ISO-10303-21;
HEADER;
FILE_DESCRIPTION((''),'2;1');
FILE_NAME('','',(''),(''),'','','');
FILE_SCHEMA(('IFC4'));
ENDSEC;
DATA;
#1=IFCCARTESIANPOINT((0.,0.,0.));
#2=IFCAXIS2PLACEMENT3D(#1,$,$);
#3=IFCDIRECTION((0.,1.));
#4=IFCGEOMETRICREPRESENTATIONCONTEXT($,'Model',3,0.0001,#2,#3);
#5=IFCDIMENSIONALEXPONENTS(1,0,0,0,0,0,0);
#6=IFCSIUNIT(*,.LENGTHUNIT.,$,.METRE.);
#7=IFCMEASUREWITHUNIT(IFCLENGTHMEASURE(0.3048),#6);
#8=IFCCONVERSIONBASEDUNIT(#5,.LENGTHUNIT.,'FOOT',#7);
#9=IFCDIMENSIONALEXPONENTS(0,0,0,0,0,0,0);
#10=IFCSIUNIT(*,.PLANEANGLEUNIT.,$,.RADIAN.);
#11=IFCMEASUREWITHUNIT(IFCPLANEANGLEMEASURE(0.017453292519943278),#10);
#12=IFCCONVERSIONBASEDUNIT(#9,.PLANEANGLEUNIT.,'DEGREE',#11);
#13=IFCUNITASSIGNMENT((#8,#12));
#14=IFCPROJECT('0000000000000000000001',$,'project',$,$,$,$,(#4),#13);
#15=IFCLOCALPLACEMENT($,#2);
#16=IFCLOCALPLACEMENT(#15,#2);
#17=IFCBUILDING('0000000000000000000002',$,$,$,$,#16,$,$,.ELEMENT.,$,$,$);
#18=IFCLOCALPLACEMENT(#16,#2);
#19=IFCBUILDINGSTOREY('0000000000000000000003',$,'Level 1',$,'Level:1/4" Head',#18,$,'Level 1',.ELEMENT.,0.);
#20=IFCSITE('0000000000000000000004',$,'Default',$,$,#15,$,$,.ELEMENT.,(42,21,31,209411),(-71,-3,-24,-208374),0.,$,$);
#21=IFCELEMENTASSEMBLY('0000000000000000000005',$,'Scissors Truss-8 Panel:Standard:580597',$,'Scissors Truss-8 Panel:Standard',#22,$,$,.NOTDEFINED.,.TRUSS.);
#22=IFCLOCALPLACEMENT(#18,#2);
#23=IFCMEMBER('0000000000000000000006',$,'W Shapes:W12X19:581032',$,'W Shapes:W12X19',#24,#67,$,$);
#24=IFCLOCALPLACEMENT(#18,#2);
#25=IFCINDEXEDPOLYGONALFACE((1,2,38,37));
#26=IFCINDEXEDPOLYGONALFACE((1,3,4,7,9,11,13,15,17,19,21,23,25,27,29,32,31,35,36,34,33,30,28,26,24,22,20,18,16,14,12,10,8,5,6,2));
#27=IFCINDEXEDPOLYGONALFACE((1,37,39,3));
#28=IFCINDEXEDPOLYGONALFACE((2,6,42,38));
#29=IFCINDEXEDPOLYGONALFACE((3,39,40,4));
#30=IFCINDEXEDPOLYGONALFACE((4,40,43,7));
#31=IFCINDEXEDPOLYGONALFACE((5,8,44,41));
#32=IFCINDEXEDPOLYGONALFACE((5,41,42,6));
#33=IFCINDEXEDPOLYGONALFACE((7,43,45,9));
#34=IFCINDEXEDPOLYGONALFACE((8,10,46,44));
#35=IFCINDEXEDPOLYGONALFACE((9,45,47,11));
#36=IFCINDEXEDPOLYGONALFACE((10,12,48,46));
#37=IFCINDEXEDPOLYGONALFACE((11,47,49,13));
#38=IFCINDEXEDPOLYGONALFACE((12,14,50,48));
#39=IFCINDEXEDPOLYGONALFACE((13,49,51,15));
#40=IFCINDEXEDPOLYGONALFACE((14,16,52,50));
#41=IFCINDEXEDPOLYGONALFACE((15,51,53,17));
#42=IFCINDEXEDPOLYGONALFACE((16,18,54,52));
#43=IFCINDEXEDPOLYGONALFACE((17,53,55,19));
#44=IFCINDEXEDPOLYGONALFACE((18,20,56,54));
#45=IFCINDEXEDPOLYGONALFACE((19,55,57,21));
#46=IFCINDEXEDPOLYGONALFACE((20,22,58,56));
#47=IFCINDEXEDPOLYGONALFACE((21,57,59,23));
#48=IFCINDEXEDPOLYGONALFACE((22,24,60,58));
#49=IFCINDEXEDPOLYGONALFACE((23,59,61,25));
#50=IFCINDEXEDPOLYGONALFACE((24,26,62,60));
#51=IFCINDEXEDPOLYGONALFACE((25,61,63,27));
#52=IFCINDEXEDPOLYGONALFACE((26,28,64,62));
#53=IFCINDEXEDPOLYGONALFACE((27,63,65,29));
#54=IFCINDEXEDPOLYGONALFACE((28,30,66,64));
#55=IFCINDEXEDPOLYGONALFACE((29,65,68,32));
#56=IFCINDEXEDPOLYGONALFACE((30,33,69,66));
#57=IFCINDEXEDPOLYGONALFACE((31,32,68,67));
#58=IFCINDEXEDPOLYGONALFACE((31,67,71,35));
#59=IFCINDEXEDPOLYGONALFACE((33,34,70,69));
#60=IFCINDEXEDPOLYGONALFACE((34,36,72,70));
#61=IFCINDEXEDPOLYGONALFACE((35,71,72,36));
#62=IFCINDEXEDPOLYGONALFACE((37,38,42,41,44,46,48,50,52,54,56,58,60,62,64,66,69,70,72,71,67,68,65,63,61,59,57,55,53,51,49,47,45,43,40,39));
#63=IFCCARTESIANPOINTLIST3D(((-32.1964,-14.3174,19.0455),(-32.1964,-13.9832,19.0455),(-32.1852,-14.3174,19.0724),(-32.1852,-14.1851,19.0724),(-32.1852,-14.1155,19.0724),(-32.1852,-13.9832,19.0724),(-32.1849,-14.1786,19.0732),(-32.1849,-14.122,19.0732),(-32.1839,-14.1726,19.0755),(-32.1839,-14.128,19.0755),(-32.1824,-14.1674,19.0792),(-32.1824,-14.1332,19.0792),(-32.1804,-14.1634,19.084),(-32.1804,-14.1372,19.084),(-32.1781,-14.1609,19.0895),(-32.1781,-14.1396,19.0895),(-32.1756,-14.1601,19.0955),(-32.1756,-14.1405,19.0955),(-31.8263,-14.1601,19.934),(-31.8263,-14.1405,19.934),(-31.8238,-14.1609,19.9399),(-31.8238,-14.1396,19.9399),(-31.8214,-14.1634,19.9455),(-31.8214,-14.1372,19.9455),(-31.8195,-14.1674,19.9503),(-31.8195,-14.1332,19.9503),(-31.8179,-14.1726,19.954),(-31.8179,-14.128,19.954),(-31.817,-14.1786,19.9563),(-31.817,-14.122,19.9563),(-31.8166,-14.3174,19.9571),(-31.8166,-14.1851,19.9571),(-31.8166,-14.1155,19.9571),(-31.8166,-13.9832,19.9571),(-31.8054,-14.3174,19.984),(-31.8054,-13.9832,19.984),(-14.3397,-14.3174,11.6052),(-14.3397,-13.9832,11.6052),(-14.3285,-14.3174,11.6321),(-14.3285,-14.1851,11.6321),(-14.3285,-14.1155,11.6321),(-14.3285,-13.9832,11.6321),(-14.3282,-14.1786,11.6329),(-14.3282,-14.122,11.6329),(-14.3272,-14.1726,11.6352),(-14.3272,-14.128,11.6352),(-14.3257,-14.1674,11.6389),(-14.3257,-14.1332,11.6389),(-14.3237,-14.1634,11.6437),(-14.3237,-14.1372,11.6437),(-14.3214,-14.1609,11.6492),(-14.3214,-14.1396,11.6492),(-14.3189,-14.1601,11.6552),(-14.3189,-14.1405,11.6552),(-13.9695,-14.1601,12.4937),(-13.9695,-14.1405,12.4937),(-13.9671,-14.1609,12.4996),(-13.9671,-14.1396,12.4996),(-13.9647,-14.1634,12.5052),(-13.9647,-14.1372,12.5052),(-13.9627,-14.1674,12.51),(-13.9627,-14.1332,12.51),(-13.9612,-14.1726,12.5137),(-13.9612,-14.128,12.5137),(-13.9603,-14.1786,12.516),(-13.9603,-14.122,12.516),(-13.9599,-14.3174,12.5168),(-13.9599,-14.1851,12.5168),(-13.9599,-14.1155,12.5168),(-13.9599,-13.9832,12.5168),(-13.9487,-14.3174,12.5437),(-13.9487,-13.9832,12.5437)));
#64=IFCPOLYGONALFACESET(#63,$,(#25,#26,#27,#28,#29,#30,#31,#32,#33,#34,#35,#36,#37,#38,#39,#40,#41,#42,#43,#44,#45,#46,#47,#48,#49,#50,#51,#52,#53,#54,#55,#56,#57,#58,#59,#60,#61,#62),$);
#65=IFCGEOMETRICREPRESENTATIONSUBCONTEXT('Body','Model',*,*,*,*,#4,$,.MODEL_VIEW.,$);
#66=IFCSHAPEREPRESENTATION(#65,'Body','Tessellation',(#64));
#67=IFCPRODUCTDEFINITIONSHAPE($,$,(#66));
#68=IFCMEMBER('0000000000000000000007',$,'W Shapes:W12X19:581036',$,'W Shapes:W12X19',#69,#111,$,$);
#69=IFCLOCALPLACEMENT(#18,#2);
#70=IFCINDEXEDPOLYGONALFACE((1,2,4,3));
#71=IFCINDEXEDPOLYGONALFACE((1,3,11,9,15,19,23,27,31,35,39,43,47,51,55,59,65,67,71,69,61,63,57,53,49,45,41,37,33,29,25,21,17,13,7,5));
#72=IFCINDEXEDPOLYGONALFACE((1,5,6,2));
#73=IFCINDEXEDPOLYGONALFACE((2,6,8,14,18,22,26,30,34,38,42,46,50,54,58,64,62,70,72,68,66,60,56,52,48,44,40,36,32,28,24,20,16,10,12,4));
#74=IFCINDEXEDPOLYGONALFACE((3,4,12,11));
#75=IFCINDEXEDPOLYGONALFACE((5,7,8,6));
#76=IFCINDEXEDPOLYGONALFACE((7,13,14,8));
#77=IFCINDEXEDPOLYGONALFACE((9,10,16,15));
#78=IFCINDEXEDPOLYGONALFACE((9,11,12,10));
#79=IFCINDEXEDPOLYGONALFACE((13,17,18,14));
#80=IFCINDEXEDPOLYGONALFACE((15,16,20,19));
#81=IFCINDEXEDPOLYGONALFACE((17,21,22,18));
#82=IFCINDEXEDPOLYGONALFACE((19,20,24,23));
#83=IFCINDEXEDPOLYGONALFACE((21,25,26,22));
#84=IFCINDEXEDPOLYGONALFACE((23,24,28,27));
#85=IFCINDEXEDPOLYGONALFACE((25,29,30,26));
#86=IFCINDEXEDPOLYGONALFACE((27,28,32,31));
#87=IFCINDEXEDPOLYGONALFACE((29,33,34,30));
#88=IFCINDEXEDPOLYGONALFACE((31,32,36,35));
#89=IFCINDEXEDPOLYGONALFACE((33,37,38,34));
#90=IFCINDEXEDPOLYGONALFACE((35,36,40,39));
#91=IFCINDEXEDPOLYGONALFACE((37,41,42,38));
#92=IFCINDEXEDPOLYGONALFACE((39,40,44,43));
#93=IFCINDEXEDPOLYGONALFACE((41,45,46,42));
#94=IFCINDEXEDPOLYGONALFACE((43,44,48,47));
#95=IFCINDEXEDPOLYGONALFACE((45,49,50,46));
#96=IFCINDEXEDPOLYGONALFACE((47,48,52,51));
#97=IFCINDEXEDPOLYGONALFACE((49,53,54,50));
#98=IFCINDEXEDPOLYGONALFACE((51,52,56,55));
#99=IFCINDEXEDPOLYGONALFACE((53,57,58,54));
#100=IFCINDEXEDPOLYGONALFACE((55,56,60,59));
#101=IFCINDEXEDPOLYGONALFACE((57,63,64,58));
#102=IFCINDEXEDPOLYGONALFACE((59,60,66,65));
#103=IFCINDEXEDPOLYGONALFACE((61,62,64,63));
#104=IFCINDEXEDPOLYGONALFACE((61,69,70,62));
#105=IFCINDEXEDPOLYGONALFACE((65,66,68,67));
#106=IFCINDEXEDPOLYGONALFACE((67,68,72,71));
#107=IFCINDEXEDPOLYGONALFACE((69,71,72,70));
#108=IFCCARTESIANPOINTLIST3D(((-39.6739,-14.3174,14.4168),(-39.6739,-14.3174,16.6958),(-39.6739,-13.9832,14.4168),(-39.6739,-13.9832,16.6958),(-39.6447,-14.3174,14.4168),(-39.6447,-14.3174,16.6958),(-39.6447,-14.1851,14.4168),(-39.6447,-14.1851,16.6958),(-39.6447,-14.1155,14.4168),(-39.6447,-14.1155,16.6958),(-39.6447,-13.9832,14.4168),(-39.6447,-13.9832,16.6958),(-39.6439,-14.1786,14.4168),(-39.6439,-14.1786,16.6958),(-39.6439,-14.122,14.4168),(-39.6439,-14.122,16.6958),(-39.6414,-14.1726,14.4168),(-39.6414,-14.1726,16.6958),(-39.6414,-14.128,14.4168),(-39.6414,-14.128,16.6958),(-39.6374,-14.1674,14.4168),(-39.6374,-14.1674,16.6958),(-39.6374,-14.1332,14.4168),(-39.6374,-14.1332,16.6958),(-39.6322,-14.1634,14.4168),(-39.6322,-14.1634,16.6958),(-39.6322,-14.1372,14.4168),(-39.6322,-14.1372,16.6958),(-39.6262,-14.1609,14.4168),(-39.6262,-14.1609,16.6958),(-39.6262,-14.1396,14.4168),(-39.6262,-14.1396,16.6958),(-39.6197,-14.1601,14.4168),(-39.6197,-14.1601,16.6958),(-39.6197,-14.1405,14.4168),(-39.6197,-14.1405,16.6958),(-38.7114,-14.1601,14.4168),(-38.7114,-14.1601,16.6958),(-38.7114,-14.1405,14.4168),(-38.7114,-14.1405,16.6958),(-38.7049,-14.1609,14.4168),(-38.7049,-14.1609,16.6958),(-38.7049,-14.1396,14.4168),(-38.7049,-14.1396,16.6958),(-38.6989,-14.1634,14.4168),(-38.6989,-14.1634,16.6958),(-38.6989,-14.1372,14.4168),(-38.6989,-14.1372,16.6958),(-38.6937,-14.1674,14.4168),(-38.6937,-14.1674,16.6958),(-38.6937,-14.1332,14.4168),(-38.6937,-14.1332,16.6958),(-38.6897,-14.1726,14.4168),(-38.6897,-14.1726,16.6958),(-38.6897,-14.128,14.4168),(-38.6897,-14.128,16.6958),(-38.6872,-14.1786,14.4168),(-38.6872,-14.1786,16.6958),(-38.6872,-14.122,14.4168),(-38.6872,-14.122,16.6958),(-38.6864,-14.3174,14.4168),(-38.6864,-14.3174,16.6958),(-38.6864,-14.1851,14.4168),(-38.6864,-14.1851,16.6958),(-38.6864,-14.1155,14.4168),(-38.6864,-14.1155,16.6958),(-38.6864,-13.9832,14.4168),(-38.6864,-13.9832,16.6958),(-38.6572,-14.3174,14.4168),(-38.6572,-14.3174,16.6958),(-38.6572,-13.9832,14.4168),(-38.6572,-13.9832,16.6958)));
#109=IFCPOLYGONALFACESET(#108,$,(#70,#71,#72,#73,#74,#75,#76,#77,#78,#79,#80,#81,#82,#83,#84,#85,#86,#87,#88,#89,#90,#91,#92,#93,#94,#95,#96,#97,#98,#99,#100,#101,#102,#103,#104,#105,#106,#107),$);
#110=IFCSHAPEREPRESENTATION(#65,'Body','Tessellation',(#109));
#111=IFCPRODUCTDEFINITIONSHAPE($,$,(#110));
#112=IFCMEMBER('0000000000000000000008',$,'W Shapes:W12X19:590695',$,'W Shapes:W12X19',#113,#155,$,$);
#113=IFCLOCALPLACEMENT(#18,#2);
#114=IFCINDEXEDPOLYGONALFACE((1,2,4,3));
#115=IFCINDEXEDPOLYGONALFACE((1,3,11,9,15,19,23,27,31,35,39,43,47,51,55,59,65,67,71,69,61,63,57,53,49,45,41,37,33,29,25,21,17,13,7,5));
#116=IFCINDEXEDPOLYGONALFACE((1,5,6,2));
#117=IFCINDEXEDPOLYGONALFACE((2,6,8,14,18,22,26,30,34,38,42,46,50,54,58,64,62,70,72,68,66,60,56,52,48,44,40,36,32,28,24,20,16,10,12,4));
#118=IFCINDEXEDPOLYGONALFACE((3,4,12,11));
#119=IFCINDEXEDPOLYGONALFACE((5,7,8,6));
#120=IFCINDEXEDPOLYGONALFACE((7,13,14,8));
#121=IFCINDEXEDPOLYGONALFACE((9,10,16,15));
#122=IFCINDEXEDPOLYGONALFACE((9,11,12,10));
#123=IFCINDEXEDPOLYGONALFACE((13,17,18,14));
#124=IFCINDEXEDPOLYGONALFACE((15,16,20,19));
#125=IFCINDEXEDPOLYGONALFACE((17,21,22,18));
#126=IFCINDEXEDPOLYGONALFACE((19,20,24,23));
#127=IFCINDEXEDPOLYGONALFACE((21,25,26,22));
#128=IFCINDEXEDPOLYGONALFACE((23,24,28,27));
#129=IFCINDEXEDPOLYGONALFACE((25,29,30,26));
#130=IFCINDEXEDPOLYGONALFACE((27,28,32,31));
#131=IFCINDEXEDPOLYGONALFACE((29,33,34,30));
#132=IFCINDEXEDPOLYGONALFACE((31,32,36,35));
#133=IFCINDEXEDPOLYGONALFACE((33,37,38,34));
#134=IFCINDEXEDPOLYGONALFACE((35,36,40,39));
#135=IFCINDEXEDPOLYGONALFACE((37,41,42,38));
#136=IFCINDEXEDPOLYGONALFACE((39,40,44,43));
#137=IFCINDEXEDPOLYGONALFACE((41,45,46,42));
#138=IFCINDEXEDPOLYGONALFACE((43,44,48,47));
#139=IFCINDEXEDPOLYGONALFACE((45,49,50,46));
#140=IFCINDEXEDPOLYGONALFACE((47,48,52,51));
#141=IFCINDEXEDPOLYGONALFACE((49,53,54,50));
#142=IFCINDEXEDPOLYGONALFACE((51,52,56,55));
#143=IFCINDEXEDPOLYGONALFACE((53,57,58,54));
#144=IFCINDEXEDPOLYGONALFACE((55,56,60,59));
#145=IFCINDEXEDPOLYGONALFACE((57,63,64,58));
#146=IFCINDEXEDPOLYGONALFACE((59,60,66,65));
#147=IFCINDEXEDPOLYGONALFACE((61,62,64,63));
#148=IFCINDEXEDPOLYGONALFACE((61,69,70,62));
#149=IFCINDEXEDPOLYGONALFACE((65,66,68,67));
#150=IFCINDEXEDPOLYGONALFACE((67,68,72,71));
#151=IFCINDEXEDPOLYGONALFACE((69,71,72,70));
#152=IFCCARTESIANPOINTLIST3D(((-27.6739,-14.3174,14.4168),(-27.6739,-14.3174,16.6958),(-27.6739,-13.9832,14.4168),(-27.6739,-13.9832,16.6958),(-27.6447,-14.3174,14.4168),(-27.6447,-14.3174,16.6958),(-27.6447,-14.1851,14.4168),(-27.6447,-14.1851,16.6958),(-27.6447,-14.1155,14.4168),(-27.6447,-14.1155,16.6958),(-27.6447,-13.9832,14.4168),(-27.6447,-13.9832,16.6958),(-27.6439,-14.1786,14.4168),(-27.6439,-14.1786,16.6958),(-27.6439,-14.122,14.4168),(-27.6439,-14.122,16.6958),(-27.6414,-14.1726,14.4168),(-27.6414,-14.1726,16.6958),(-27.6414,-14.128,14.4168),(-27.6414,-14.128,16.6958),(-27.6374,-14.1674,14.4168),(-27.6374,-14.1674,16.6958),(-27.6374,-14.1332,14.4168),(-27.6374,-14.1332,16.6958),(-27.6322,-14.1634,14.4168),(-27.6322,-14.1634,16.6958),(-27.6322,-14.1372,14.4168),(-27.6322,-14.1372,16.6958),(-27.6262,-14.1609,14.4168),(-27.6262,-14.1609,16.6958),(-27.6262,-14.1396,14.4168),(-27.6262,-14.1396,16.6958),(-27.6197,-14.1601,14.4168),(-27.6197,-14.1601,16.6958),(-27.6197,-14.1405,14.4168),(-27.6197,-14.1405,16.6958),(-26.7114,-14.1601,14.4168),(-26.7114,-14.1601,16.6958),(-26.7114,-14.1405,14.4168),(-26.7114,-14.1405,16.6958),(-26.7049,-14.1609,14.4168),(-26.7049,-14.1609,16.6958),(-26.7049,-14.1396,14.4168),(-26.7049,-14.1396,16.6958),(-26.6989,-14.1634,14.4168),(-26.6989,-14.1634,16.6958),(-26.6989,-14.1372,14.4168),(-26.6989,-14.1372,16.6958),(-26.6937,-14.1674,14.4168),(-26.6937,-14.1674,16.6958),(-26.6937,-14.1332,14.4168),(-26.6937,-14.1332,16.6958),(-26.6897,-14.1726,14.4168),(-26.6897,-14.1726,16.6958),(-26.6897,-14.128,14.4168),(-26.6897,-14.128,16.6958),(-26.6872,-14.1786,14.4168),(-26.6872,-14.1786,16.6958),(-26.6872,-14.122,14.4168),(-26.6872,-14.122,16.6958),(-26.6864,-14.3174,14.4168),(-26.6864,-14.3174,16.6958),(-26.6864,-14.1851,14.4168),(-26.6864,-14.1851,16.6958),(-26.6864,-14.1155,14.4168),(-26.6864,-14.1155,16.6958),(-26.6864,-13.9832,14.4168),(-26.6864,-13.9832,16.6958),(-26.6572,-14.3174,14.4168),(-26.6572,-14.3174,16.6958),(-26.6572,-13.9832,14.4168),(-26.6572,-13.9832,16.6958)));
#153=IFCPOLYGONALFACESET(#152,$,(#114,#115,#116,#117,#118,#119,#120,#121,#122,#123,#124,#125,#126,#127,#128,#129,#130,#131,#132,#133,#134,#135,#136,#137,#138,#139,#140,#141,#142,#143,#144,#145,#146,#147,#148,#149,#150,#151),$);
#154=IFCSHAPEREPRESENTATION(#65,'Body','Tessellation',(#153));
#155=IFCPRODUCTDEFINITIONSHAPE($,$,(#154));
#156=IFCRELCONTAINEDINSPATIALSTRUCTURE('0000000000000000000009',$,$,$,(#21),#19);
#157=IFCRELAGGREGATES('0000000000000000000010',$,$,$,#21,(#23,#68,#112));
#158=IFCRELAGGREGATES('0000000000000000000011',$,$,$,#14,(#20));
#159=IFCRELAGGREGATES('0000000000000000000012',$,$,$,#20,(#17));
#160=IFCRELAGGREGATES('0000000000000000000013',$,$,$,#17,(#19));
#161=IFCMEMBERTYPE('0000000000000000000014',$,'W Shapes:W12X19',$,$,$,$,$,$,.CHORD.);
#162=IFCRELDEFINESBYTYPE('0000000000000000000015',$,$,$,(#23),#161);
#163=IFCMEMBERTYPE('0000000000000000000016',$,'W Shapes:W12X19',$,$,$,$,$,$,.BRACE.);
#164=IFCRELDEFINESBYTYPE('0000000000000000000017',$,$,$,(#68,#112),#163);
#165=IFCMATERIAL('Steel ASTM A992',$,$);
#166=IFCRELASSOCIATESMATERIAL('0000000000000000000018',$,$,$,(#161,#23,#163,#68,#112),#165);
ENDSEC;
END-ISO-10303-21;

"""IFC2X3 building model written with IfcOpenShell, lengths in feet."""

from ifc_helpers import new_model, entity, si_unit, converted_unit, direction, frame, frame_2d, origin, place, context, subcontext, project, spatial, polyline, circle_curve, parameter, trimmed, segment, composite_curve, i_section, outline, extrude, source, transform, mapped, material, type_object, type_shapes, element, aggregate, save


model = new_model("IFC2X3")

# Units and contexts
model_context = context("Model", 3, precision=0.0001, world=origin(), true_north=direction((0.0, 1.0)))
body_context = subcontext(model_context, "Body", "Model", "MODEL_VIEW")
ifc_project = project(units=[converted_unit("LENGTHUNIT", "FOOT", entity("IfcLengthMeasure", 0.3048), si_unit("LENGTHUNIT", "METRE"), dimensions=[1, 0, 0, 0, 0, 0, 0]), converted_unit("PLANEANGLEUNIT", "DEGREE", entity("IfcPlaneAngleMeasure", 0.017453292519943278), si_unit("PLANEANGLEUNIT", "RADIAN"), dimensions=[0, 0, 0, 0, 0, 0, 0])], contexts=[model_context])

# Site, building, storey
site_placement = place(None, origin())
site = spatial("IfcSite", under=ifc_project, at=site_placement, Name="Default", CompositionType="ELEMENT", RefLatitude=(42, 21, 31, 209411), RefLongitude=(-71, -3, -24, -208374), RefElevation=0.0)
building_placement = place(site_placement, origin())
building = spatial("IfcBuilding", under=site, at=building_placement, CompositionType="ELEMENT")
storey_placement = place(building_placement, origin())
storey = spatial("IfcBuildingStorey", under=building, at=storey_placement, Name="Level 1", ObjectType="Level:1/4\" Head", LongName="Level 1", CompositionType="ELEMENT", Elevation=0.0)

# Element assembly, members
assembly_placement = place(storey_placement, origin())
assembly = element("IfcElementAssembly", 1, at=assembly_placement, inside=storey, Name="Scissors Truss-8 Panel:Standard:580597", ObjectType="Scissors Truss-8 Panel:Standard", AssemblyPlace="NOTDEFINED", PredefinedType="TRUSS")
ifc_material = material(Name="Steel ASTM A992")
member_type_1 = type_object("IfcMemberType", Name="W Shapes:W12X19", PredefinedType="CHORD", material=ifc_material)
shared_shape_1 = source(origin(), body_context, "Body", "SweptSolid", [
    extrude(i_section(OverallWidth=0.3342, OverallDepth=1.0167, WebThickness=0.0196, FlangeThickness=0.0292, FilletRadius=0.025, at=frame_2d((0.0, 0.0), x_axis=(1.0, 0.0))), frame((-32.0009, -14.1503, 19.5147), z_axis=(0.923077, 0.0, -0.384615), x_axis=(0.0, 1.0, 0.0)), (0.0, 0.0, 1.0), 19.3448),
])
type_shapes(member_type_1, [shared_shape_1])
member_1_placement = place(assembly_placement, origin())
member_1 = element("IfcMember", 2, at=member_1_placement, type_object=member_type_1, material=ifc_material, Name="W Shapes:W12X19:581032", ObjectType="W Shapes:W12X19", context=body_context, shape_type="MappedRepresentation", body=[
    mapped(shared_shape_1, transform((0.0, 0.0, 0.0), scale=1.0)),
])
member_type_2 = type_object("IfcMemberType", Name="W Shapes:W12X19", PredefinedType="BRACE", material=ifc_material)
shared_shape_2 = source(origin(), body_context, "Body", "SweptSolid", [
    extrude(outline(composite_curve([segment(polyline([(-0.1671, -0.4792), (-0.1671, -0.5083)]), True, "CONTINUOUS"), segment(polyline([(-0.1671, -0.5083), (0.1671, -0.5083)]), True, "CONTINUOUS"), segment(polyline([(0.1671, -0.5083), (0.1671, -0.4792)]), True, "CONTINUOUS"), segment(polyline([(0.1671, -0.4792), (0.0348, -0.4792)]), True, "CONTINUOUS"), segment(trimmed(circle_curve(frame_2d((0.0348, -0.4542), x_axis=(1.0, 0.0)), 0.025), [parameter(180.0)], [parameter(270.0)], True, "PARAMETER"), False, "CONTINUOUS"), segment(polyline([(0.0098, -0.4542), (0.0098, 0.4542)]), True, "CONTINUOUS"), segment(trimmed(circle_curve(frame_2d((0.0348, 0.4542), x_axis=(1.0, 0.0)), 0.025), [parameter(90.0)], [parameter(180.0)], True, "PARAMETER"), False, "CONTINUOUS"), segment(polyline([(0.0348, 0.4792), (0.1671, 0.4792)]), True, "CONTINUOUS"), segment(polyline([(0.1671, 0.4792), (0.1671, 0.5083)]), True, "CONTINUOUS"), segment(polyline([(0.1671, 0.5083), (-0.1671, 0.5083)]), True, "CONTINUOUS"), segment(polyline([(-0.1671, 0.5083), (-0.1671, 0.4792)]), True, "CONTINUOUS"), segment(polyline([(-0.1671, 0.4792), (-0.0348, 0.4792)]), True, "CONTINUOUS"), segment(trimmed(circle_curve(frame_2d((-0.0348, 0.4542), x_axis=(1.0, 0.0)), 0.025), [parameter(360.0)], [parameter(90.0)], True, "PARAMETER"), False, "CONTINUOUS"), segment(polyline([(-0.0098, 0.4542), (-0.0098, -0.4542)]), True, "CONTINUOUS"), segment(trimmed(circle_curve(frame_2d((-0.0348, -0.4542), x_axis=(1.0, 0.0)), 0.025), [parameter(270.0)], [parameter(360.0)], True, "PARAMETER"), False, "CONTINUOUS"), segment(polyline([(-0.0348, -0.4792), (-0.1671, -0.4792)]), True, "CONTINUOUS")], self_intersect=False)), frame((-1.2082, 0.0, 0.0), z_axis=(-1.0, 0.0, 0.0), x_axis=(0.0, -1.0, 0.0)), (0.0, 0.0, -1.0), 2.279),
])
type_shapes(member_type_2, [shared_shape_2])
member_2_placement = place(assembly_placement, frame((-39.1655, -14.1503, 15.625), z_axis=(1.0, 0.0, 0.0), x_axis=(0.0, 0.0, 1.0)))
member_2 = element("IfcMember", 3, at=member_2_placement, type_object=member_type_2, material=ifc_material, Name="W Shapes:W12X19:581036", ObjectType="W Shapes:W12X19", context=body_context, shape_type="MappedRepresentation", body=[
    mapped(shared_shape_2, transform((0.0, 0.0, 0.0), scale=1.0)),
])
member_3_placement = place(assembly_placement, frame((-27.1655, -14.1503, 15.625), z_axis=(1.0, 0.0, 0.0), x_axis=(0.0, 0.0, 1.0)))
member_3 = element("IfcMember", 4, at=member_3_placement, type_object=member_type_2, material=ifc_material, Name="W Shapes:W12X19:590695", ObjectType="W Shapes:W12X19", context=body_context, shape_type="MappedRepresentation", body=[
    mapped(shared_shape_2, transform((0.0, 0.0, 0.0), scale=1.0)),
])
aggregate(assembly, [member_1, member_2, member_3])

save(model, "model.ifc")
